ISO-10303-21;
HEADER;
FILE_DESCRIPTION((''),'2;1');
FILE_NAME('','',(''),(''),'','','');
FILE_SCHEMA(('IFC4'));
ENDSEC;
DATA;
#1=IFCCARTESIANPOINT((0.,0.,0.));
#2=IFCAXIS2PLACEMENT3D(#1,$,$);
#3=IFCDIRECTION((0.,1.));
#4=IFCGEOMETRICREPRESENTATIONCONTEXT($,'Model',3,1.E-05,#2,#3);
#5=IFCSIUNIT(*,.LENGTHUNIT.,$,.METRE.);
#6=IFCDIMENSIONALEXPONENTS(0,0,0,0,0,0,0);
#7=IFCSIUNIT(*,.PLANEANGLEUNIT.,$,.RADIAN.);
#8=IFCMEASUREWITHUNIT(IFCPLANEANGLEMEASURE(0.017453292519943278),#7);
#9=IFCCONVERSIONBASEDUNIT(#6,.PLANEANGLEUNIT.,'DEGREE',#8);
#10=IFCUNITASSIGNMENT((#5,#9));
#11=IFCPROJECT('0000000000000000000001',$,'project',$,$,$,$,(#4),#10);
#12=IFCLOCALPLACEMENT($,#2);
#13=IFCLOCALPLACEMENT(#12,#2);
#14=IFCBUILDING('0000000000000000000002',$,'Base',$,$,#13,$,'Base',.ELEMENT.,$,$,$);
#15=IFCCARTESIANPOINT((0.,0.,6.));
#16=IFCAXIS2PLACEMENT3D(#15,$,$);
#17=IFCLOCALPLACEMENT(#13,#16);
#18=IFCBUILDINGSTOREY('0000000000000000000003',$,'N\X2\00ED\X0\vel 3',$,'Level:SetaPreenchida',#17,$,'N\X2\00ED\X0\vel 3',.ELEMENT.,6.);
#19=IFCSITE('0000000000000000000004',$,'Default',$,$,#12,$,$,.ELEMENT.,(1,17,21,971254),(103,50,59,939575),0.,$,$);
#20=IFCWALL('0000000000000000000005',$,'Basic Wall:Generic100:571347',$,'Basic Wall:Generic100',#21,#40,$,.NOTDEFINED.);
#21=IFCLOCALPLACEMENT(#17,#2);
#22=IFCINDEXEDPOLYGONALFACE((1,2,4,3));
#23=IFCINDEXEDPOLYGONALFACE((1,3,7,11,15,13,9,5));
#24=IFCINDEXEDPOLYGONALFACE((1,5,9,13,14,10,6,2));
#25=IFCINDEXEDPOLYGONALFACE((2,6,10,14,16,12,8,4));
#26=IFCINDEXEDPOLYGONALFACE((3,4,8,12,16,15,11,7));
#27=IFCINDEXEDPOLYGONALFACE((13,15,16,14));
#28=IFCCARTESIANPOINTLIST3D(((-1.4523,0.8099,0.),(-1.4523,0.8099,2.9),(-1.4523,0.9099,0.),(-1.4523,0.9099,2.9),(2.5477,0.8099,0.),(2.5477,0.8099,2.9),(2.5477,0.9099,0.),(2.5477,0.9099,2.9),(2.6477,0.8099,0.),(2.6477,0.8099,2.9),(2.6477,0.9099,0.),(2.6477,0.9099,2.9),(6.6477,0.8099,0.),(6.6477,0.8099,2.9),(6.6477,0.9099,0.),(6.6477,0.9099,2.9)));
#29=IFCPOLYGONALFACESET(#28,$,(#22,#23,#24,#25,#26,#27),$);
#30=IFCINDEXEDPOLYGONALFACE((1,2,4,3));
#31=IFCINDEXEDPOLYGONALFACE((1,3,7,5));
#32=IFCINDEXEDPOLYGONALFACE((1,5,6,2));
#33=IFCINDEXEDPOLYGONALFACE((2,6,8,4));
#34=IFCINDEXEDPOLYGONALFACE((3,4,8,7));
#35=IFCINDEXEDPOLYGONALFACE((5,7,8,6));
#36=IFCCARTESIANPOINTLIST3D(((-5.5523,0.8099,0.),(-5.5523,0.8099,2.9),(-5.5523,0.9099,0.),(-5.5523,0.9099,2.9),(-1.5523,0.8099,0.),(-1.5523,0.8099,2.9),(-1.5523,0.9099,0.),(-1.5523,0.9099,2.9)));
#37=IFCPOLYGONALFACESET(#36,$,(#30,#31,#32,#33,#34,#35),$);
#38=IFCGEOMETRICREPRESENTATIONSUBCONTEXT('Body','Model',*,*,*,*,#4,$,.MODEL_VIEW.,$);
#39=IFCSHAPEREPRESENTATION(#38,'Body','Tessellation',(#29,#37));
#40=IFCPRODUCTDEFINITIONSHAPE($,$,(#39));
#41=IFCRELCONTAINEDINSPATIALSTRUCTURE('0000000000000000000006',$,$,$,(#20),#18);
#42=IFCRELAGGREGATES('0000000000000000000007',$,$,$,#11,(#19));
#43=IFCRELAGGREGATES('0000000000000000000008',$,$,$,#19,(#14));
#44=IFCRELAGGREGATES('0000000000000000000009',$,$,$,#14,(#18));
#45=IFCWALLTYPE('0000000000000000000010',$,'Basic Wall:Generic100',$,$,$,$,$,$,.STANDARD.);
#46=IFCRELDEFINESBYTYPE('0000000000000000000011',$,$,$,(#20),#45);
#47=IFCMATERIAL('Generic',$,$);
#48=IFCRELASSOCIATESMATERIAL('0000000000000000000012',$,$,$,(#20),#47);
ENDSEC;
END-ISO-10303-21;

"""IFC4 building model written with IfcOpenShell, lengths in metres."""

from ifc_helpers import new_model, entity, si_unit, converted_unit, direction, frame, origin, place, context, subcontext, project, spatial, indexed_curve, outline, extrude, material, type_object, element, save


model = new_model("IFC4")

# Units and contexts
model_context = context("Model", 3, precision=1e-05, world=origin(), true_north=direction((0.0, 1.0)))
body_context = subcontext(model_context, "Body", "Model", "MODEL_VIEW")
ifc_project = project(units=[si_unit("LENGTHUNIT", "METRE"), converted_unit("PLANEANGLEUNIT", "DEGREE", entity("IfcPlaneAngleMeasure", 0.017453292519943278), si_unit("PLANEANGLEUNIT", "RADIAN"), dimensions=[0, 0, 0, 0, 0, 0, 0])], contexts=[model_context])

# Site, building, storey
site_placement = place(None, origin())
site = spatial("IfcSite", under=ifc_project, at=site_placement, Name="Default", CompositionType="ELEMENT", RefLatitude=(1, 17, 21, 971254), RefLongitude=(103, 50, 59, 939575), RefElevation=0.0)
building_placement = place(site_placement, origin())
building = spatial("IfcBuilding", under=site, at=building_placement, Name="Base", LongName="Base", CompositionType="ELEMENT")
storey_placement = place(building_placement, frame((0.0, 0.0, 6.0)))
storey = spatial("IfcBuildingStorey", under=building, at=storey_placement, Name="Nível 3", ObjectType="Level:SetaPreenchida", LongName="Nível 3", CompositionType="ELEMENT", Elevation=6.0)

# Shared definitions
ifc_material = material(Name="Generic")

# Wall
wall_type = type_object("IfcWallType", Name="Basic Wall:Generic100", PredefinedType="STANDARD")
wall_placement = place(storey_placement, frame((6.6477, 0.8599, 0.0), z_axis=(0.0, 0.0, 1.0), x_axis=(-1.0, 0.0, 0.0)))
element("IfcWall", 1, at=wall_placement, inside=storey, type_object=wall_type, material=ifc_material, Name="Basic Wall:Generic100:571347", ObjectType="Basic Wall:Generic100", PredefinedType="NOTDEFINED", context=body_context, shape_type="SweptSolid", body=[
    extrude(outline(indexed_curve([(-4.05, -0.05), (-0.05, -0.05), (0.05, -0.05), (4.05, -0.05), (4.05, 0.05), (0.05, 0.05), (-0.05, 0.05), (-4.05, 0.05), (-4.05, -0.05)], self_intersect=False)), frame((4.05, 0.0, 0.0)), (0.0, 0.0, 1.0), 2.9),
    extrude(outline(indexed_curve([(-2.0, -0.05), (2.0, -0.05), (2.0, 0.05), (-2.0, 0.05), (-2.0, -0.05)], self_intersect=False)), frame((10.2, 0.0, 0.0), z_axis=(0.0, 0.0, 1.0), x_axis=(-1.0, 0.0, 0.0)), (0.0, 0.0, 1.0), 2.9),
])

save(model, "model.ifc")
